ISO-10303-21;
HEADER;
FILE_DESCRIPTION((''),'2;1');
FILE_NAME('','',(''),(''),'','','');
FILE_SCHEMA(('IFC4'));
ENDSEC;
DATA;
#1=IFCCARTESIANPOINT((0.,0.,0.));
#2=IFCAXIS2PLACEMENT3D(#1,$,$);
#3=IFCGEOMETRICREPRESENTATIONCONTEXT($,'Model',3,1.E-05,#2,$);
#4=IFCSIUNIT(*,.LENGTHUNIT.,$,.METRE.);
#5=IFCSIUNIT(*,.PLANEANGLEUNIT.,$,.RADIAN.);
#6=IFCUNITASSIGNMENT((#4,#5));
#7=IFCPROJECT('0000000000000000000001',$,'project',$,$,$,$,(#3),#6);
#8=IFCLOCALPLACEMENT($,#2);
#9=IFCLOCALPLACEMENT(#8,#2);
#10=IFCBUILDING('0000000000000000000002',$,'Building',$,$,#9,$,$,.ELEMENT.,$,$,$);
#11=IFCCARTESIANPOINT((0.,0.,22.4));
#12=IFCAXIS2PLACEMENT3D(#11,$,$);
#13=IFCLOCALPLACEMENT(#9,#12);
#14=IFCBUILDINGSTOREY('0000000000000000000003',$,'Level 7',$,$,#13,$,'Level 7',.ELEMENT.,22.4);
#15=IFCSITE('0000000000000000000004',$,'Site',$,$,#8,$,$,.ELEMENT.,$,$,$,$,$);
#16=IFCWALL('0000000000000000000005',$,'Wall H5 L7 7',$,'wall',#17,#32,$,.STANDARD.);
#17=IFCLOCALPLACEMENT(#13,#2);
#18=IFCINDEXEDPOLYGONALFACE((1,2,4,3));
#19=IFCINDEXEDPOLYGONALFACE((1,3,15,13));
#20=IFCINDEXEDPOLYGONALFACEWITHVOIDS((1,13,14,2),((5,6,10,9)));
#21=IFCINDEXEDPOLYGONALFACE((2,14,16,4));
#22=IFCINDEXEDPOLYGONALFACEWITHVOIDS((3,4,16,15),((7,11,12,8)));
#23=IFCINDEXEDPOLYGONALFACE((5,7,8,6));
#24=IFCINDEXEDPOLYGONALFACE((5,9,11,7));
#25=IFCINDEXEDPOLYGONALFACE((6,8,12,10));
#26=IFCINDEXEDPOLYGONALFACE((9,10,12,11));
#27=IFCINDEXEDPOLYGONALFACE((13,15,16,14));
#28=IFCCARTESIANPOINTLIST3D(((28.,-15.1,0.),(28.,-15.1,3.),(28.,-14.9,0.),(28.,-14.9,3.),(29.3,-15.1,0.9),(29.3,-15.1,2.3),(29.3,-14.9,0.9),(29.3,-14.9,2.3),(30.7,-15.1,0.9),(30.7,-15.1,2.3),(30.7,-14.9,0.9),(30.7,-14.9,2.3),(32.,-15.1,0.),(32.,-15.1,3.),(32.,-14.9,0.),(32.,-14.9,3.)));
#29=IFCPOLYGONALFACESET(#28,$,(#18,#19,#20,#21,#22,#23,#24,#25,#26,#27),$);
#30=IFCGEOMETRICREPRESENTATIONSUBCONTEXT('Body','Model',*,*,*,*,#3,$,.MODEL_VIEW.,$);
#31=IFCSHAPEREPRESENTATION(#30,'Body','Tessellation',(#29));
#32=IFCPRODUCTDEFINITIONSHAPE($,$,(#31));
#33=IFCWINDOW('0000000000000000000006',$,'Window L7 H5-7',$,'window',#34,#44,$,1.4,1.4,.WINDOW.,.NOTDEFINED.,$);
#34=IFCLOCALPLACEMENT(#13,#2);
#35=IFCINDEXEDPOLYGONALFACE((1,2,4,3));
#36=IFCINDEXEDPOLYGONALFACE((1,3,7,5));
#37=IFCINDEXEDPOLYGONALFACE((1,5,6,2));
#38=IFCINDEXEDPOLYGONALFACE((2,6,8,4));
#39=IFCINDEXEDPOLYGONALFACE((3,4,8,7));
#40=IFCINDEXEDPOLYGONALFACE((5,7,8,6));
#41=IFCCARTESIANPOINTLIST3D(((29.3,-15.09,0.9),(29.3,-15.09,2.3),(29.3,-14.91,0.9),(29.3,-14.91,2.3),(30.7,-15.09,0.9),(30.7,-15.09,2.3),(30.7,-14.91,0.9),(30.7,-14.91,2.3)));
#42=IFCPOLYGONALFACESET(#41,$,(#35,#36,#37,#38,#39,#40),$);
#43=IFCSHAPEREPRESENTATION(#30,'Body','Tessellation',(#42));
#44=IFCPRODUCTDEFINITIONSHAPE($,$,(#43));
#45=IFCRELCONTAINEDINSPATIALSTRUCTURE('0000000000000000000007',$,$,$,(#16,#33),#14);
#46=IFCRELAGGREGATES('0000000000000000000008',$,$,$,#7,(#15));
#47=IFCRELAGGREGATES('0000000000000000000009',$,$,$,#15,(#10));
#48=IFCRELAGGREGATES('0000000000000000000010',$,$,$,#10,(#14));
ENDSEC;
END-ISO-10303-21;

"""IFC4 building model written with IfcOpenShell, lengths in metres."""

from ifc_helpers import new_model, si_unit, frame, frame_2d, origin, origin_2d, place, context, subcontext, project, spatial, rectangle, extrude, element, fill, save


model = new_model("IFC4")

# Units and contexts
model_context = context("Model", 3, precision=1e-05, world=origin())
body_context = subcontext(model_context, "Body", "Model", "MODEL_VIEW")
ifc_project = project(units=[si_unit("LENGTHUNIT", "METRE"), si_unit("PLANEANGLEUNIT", "RADIAN")], contexts=[model_context])

# Site, building, storey
site_placement = place(None, origin())
site = spatial("IfcSite", under=ifc_project, at=site_placement, Name="Site", CompositionType="ELEMENT")
building_placement = place(site_placement, origin())
building = spatial("IfcBuilding", under=site, at=building_placement, Name="Building", CompositionType="ELEMENT")
storey_placement = place(building_placement, frame((0.0, 0.0, 22.4)))
storey = spatial("IfcBuildingStorey", under=building, at=storey_placement, Name="Level 7", LongName="Level 7", CompositionType="ELEMENT", Elevation=22.4)

# Wall, opening, window
wall_1_placement = place(storey_placement, frame((28.0, -15.0, 0.0), z_axis=(0.0, 0.0, 1.0), x_axis=(1.0, 0.0, 0.0)))
wall_1 = element("IfcWall", 1, at=wall_1_placement, inside=storey, Name="Wall H5 L7 7", ObjectType="wall", PredefinedType="STANDARD", context=body_context, shape_type="SweptSolid", body=[
    extrude(rectangle(XDim=4.0, YDim=0.2, at=frame_2d((2.0, 0.0))), origin(), (0.0, 0.0, 1.0), 3.0),
])
opening_1_placement = place(storey_placement, frame((30.0, -15.0, 0.9), z_axis=(0.0, 0.0, 1.0), x_axis=(1.0, 0.0, 0.0)))
opening_1 = element("IfcOpeningElement", 2, at=opening_1_placement, cuts=wall_1, ObjectType="Opening", PredefinedType="OPENING", context=body_context, shape_type="SweptSolid", body=[
    extrude(rectangle(XDim=1.4, YDim=0.22, at=origin_2d()), origin(), (0.0, 0.0, 1.0), 1.4),
])
window_1_placement = place(storey_placement, frame((30.0, -15.0, 0.9), z_axis=(0.0, 0.0, 1.0), x_axis=(1.0, 0.0, 0.0)))
window_1 = element("IfcWindow", 3, at=window_1_placement, inside=storey, Name="Window L7 H5-7", ObjectType="window", OverallHeight=1.4, OverallWidth=1.4, PartitioningType="NOTDEFINED", PredefinedType="WINDOW", context=body_context, shape_type="SweptSolid", body=[
    extrude(rectangle(XDim=1.4, YDim=0.18, at=origin_2d()), origin(), (0.0, 0.0, 1.0), 1.4),
])
fill(opening_1, window_1)

save(model, "model.ifc")
